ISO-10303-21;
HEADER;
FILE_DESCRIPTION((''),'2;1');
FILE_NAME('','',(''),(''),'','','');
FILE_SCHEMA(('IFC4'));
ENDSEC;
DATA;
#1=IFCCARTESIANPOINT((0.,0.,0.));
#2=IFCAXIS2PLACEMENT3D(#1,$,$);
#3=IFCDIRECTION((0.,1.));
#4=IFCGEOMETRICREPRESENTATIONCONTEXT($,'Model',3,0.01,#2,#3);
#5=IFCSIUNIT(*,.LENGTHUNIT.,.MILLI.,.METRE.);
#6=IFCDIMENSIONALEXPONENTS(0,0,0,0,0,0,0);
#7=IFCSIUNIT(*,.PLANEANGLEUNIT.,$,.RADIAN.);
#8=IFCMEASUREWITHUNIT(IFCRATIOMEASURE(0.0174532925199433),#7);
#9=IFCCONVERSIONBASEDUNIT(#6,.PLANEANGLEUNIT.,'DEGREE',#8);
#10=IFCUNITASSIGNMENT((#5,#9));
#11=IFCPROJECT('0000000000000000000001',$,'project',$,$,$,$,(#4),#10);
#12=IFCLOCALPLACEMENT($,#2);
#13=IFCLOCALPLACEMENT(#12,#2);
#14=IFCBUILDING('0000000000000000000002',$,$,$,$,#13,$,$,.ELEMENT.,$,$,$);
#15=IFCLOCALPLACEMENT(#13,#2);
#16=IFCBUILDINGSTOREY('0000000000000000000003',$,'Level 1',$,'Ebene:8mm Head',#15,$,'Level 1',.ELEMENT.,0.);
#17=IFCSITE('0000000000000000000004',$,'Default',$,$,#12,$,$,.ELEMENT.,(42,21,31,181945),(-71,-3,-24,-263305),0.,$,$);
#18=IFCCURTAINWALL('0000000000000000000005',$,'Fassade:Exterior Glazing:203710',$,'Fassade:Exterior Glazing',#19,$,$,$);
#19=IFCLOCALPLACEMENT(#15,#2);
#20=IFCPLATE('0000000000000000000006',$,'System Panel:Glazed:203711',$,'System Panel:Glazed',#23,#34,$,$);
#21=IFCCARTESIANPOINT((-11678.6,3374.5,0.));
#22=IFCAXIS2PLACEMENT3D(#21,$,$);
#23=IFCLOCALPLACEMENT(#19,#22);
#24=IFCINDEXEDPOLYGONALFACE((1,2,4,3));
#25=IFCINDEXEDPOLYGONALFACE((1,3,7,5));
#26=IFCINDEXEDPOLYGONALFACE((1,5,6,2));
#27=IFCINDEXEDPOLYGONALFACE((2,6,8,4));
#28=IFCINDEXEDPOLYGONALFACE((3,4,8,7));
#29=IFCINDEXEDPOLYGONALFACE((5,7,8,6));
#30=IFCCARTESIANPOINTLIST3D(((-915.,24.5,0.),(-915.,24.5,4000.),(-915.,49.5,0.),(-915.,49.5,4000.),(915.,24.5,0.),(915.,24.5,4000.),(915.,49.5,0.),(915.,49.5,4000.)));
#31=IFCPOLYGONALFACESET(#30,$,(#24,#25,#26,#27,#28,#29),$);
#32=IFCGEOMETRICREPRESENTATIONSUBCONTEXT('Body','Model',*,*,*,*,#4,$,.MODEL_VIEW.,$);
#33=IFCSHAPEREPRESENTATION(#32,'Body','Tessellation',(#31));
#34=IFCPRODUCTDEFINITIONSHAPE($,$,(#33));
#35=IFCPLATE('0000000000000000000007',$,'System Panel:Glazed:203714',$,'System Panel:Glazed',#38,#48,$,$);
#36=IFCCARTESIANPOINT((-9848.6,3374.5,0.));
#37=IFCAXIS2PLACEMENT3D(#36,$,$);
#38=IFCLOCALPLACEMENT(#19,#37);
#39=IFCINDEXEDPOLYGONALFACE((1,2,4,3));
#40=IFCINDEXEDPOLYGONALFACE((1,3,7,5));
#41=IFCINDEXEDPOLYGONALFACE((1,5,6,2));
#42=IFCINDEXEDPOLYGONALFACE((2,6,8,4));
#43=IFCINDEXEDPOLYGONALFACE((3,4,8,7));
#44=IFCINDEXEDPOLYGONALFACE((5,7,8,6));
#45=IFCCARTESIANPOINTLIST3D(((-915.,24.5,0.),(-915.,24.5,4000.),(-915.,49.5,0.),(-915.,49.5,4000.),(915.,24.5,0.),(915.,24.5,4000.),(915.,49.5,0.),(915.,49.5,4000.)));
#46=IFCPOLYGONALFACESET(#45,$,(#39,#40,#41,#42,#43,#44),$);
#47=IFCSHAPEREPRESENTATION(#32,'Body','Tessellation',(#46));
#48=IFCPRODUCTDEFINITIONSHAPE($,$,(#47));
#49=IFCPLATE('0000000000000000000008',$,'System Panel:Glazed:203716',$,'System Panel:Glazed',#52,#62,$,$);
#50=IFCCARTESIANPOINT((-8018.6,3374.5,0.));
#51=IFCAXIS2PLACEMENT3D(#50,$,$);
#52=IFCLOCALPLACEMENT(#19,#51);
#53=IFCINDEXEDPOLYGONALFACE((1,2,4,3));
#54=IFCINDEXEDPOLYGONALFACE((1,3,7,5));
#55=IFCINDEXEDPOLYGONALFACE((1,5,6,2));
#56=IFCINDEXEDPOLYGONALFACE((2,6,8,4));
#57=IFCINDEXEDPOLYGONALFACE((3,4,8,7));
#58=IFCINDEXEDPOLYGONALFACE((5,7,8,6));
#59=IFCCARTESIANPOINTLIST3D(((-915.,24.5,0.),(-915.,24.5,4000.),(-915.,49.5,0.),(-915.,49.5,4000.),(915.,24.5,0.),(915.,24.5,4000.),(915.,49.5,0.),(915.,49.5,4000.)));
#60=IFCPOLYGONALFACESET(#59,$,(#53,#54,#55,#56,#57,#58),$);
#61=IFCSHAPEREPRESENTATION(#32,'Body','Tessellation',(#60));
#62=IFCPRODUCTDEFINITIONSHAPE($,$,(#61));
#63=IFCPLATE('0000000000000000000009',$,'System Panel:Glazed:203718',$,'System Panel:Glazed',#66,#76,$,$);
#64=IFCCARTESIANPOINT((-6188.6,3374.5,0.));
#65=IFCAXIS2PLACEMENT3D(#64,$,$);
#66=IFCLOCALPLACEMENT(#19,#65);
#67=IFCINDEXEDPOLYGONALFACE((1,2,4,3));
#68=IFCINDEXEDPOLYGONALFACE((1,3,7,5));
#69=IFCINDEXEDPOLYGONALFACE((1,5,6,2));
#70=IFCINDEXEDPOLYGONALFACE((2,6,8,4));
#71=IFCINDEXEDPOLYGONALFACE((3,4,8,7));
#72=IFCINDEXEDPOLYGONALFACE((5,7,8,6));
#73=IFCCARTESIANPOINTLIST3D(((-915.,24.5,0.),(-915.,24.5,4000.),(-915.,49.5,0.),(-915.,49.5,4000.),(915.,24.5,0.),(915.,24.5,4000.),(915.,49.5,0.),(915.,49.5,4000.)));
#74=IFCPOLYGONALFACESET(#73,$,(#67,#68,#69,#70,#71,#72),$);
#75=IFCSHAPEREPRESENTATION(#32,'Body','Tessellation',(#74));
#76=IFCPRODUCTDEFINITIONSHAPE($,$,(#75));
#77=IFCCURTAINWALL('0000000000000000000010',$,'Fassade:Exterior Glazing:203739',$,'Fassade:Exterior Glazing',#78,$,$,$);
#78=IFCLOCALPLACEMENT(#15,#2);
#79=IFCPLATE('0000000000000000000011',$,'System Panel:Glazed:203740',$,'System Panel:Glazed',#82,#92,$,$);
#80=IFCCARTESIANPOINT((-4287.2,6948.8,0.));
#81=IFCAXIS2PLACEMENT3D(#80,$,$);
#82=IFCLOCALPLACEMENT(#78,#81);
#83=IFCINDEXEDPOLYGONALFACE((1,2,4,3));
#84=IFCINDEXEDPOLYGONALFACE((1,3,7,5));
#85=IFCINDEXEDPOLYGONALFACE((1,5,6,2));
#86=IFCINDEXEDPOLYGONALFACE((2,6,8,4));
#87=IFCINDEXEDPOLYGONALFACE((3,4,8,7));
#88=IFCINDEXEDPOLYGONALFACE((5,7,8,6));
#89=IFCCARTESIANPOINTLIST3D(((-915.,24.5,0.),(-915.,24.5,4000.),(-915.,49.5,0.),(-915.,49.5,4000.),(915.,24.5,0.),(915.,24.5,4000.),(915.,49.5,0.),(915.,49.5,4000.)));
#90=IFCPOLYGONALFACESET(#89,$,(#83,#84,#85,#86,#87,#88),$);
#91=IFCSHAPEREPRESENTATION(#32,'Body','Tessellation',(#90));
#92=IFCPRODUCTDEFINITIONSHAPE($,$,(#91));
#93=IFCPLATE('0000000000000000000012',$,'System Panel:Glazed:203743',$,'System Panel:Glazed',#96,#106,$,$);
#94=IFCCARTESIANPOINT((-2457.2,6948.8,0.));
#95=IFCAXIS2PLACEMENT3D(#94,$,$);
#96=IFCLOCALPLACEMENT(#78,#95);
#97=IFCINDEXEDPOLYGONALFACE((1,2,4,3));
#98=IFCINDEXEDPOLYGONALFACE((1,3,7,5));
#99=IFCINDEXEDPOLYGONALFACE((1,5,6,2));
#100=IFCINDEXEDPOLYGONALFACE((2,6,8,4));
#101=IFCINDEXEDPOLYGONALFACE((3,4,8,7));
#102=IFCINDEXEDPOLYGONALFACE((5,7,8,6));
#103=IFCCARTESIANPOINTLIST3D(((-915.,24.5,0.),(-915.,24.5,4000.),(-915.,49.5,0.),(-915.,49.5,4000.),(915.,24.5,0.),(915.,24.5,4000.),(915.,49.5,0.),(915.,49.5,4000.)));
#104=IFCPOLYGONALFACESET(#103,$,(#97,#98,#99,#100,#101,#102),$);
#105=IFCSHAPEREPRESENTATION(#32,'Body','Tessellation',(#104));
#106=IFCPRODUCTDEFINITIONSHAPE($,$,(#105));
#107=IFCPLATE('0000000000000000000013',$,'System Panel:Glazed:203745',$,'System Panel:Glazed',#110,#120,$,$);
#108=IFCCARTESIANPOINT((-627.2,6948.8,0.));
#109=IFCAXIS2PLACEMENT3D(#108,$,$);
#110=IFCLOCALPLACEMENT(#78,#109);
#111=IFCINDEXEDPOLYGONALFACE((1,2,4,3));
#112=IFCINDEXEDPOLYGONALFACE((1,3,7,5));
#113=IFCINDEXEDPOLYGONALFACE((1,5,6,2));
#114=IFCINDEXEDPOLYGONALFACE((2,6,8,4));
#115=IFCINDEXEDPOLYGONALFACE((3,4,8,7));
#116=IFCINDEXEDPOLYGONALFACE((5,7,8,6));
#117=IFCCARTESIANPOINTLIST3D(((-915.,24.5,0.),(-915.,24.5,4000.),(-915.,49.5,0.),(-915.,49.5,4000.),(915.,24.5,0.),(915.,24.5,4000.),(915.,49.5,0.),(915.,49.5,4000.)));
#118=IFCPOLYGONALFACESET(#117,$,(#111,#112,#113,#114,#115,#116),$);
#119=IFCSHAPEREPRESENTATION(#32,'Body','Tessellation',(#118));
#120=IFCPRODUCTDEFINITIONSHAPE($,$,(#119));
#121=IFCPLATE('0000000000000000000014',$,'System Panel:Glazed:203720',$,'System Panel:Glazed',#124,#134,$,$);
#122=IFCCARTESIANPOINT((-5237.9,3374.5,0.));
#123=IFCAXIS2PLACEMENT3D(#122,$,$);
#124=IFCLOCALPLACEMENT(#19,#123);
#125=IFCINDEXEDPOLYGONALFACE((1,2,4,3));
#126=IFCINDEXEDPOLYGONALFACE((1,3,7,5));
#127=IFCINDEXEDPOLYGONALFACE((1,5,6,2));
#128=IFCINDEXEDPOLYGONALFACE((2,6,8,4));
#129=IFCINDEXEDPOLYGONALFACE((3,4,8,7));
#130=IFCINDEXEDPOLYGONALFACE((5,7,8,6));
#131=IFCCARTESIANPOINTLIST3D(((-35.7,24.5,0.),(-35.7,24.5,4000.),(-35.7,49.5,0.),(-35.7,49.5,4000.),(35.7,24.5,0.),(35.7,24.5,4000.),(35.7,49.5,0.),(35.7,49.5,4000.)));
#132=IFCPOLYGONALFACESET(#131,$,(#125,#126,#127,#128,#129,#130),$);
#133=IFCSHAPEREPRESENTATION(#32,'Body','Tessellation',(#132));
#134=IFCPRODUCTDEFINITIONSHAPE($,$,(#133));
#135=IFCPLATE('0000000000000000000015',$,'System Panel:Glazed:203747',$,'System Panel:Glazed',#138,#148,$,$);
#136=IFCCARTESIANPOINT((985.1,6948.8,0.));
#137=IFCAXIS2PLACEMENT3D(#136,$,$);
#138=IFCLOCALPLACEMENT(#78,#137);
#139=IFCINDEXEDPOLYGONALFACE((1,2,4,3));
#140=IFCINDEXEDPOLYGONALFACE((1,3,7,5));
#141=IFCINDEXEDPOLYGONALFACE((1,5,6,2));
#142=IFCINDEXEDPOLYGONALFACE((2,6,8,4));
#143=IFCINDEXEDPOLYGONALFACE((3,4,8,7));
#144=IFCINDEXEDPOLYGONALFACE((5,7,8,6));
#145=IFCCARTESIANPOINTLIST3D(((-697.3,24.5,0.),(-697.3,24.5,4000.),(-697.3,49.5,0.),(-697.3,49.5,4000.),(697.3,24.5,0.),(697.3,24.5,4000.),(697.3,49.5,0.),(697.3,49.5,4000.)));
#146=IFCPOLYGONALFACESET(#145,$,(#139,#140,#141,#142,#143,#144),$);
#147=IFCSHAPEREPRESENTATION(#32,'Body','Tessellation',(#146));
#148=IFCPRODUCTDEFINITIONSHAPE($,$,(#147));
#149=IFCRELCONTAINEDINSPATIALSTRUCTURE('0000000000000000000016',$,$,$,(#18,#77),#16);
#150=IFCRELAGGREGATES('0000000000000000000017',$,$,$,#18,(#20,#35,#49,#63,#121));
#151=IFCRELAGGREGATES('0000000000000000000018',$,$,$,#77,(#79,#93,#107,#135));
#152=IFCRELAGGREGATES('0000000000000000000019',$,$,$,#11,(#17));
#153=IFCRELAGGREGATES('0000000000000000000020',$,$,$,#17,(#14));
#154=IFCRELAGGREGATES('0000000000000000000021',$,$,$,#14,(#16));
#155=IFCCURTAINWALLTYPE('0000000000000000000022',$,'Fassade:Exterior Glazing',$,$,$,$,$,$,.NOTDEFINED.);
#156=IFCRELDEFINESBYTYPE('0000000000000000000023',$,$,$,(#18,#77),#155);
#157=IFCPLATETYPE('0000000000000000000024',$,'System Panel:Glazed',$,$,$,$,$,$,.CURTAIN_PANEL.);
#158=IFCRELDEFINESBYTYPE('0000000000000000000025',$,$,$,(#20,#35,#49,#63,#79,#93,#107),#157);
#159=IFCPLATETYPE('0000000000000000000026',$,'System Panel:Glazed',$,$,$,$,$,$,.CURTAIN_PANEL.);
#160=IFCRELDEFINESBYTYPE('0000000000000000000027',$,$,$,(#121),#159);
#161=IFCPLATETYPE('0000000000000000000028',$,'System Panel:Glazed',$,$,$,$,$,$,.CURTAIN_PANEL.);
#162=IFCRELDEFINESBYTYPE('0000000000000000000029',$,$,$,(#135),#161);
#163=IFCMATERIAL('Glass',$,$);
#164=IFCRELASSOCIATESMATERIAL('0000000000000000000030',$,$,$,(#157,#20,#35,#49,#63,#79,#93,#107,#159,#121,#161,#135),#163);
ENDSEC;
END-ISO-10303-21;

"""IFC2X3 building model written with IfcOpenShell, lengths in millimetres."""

from ifc_helpers import new_model, entity, si_unit, converted_unit, direction, frame, origin, origin_2d_with_axis, place, context, subcontext, project, spatial, rectangle, extrude, source, transform, mapped, material, type_object, type_shapes, element, aggregate, save


model = new_model("IFC2X3")

# Units and contexts
model_context = context("Model", 3, precision=0.01, world=origin(), true_north=direction((0.0, 1.0)))
body_context = subcontext(model_context, "Body", "Model", "MODEL_VIEW")
ifc_project = project(units=[si_unit("LENGTHUNIT", "METRE", prefix="MILLI"), converted_unit("PLANEANGLEUNIT", "DEGREE", entity("IfcRatioMeasure", 0.0174532925199433), si_unit("PLANEANGLEUNIT", "RADIAN"), dimensions=[0, 0, 0, 0, 0, 0, 0])], contexts=[model_context])

# Site, building, storey
site_placement = place(None, origin())
site = spatial("IfcSite", under=ifc_project, at=site_placement, Name="Default", CompositionType="ELEMENT", RefLatitude=(42, 21, 31, 181945), RefLongitude=(-71, -3, -24, -263305), RefElevation=0.0)
building_placement = place(site_placement, origin())
building = spatial("IfcBuilding", under=site, at=building_placement, CompositionType="ELEMENT")
storey_placement = place(building_placement, origin())
storey = spatial("IfcBuildingStorey", under=building, at=storey_placement, Name="Level 1", ObjectType="Ebene:8mm Head", LongName="Level 1", CompositionType="ELEMENT", Elevation=0.0)

# Curtain walls, plates
curtain_wall_type = type_object("IfcCurtainWallType", Name="Fassade:Exterior Glazing", PredefinedType="NOTDEFINED")
curtain_wall_1_placement = place(storey_placement, origin())
curtain_wall_1 = element("IfcCurtainWall", 1, at=curtain_wall_1_placement, inside=storey, type_object=curtain_wall_type, Name="Fassade:Exterior Glazing:203710", ObjectType="Fassade:Exterior Glazing")
ifc_material_1 = material(Name="Glass")
plate_type_1 = type_object("IfcPlateType", Name="System Panel:Glazed", PredefinedType="CURTAIN_PANEL", material=ifc_material_1)
shared_shape_1 = source(origin(), body_context, "Body", "SweptSolid", [
    extrude(rectangle(XDim=25.0, YDim=1830.0, at=origin_2d_with_axis()), frame((0.0, 37.0, 0.0), z_axis=(0.0, 0.0, 1.0), x_axis=(0.0, 1.0, 0.0)), (0.0, 0.0, 1.0), 4000.0),
])
type_shapes(plate_type_1, [shared_shape_1])
plate_1_placement = place(curtain_wall_1_placement, frame((-11678.6, 3374.5, 0.0)))
plate_1 = element("IfcPlate", 2, at=plate_1_placement, type_object=plate_type_1, material=ifc_material_1, Name="System Panel:Glazed:203711", ObjectType="System Panel:Glazed", context=body_context, shape_type="MappedRepresentation", body=[
    mapped(shared_shape_1, transform((0.0, 0.0, 0.0), scale=1.0)),
])
plate_2_placement = place(curtain_wall_1_placement, frame((-9848.6, 3374.5, 0.0)))
plate_2 = element("IfcPlate", 3, at=plate_2_placement, type_object=plate_type_1, material=ifc_material_1, Name="System Panel:Glazed:203714", ObjectType="System Panel:Glazed", context=body_context, shape_type="MappedRepresentation", body=[
    mapped(shared_shape_1, transform((0.0, 0.0, 0.0), scale=1.0)),
])
plate_3_placement = place(curtain_wall_1_placement, frame((-8018.6, 3374.5, 0.0)))
plate_3 = element("IfcPlate", 4, at=plate_3_placement, type_object=plate_type_1, material=ifc_material_1, Name="System Panel:Glazed:203716", ObjectType="System Panel:Glazed", context=body_context, shape_type="MappedRepresentation", body=[
    mapped(shared_shape_1, transform((0.0, 0.0, 0.0), scale=1.0)),
])
plate_4_placement = place(curtain_wall_1_placement, frame((-6188.6, 3374.5, 0.0)))
plate_4 = element("IfcPlate", 5, at=plate_4_placement, type_object=plate_type_1, material=ifc_material_1, Name="System Panel:Glazed:203718", ObjectType="System Panel:Glazed", context=body_context, shape_type="MappedRepresentation", body=[
    mapped(shared_shape_1, transform((0.0, 0.0, 0.0), scale=1.0)),
])
curtain_wall_2_placement = place(storey_placement, origin())
curtain_wall_2 = element("IfcCurtainWall", 6, at=curtain_wall_2_placement, inside=storey, type_object=curtain_wall_type, Name="Fassade:Exterior Glazing:203739", ObjectType="Fassade:Exterior Glazing")
plate_5_placement = place(curtain_wall_2_placement, frame((-4287.2, 6948.8, 0.0)))
plate_5 = element("IfcPlate", 7, at=plate_5_placement, type_object=plate_type_1, material=ifc_material_1, Name="System Panel:Glazed:203740", ObjectType="System Panel:Glazed", context=body_context, shape_type="MappedRepresentation", body=[
    mapped(shared_shape_1, transform((0.0, 0.0, 0.0), scale=1.0)),
])
plate_6_placement = place(curtain_wall_2_placement, frame((-2457.2, 6948.8, 0.0)))
plate_6 = element("IfcPlate", 8, at=plate_6_placement, type_object=plate_type_1, material=ifc_material_1, Name="System Panel:Glazed:203743", ObjectType="System Panel:Glazed", context=body_context, shape_type="MappedRepresentation", body=[
    mapped(shared_shape_1, transform((0.0, 0.0, 0.0), scale=1.0)),
])
plate_7_placement = place(curtain_wall_2_placement, frame((-627.2, 6948.8, 0.0)))
plate_7 = element("IfcPlate", 9, at=plate_7_placement, type_object=plate_type_1, material=ifc_material_1, Name="System Panel:Glazed:203745", ObjectType="System Panel:Glazed", context=body_context, shape_type="MappedRepresentation", body=[
    mapped(shared_shape_1, transform((0.0, 0.0, 0.0), scale=1.0)),
])

# Plates
plate_type_2 = type_object("IfcPlateType", Name="System Panel:Glazed", PredefinedType="CURTAIN_PANEL", material=ifc_material_1)
shared_shape_2 = source(origin(), body_context, "Body", "SweptSolid", [
    extrude(rectangle(XDim=25.0, YDim=71.4, at=origin_2d_with_axis()), frame((0.0, 37.0, 0.0), z_axis=(0.0, 0.0, 1.0), x_axis=(0.0, 1.0, 0.0)), (0.0, 0.0, 1.0), 4000.0),
])
type_shapes(plate_type_2, [shared_shape_2])
plate_8_placement = place(curtain_wall_1_placement, frame((-5237.9, 3374.5, 0.0)))
plate_8 = element("IfcPlate", 10, at=plate_8_placement, type_object=plate_type_2, material=ifc_material_1, Name="System Panel:Glazed:203720", ObjectType="System Panel:Glazed", context=body_context, shape_type="MappedRepresentation", body=[
    mapped(shared_shape_2, transform((0.0, 0.0, 0.0), scale=1.0)),
])
aggregate(curtain_wall_1, [plate_1, plate_2, plate_3, plate_4, plate_8])
plate_type_3 = type_object("IfcPlateType", Name="System Panel:Glazed", PredefinedType="CURTAIN_PANEL", material=ifc_material_1)
shared_shape_3 = source(origin(), body_context, "Body", "SweptSolid", [
    extrude(rectangle(XDim=25.0, YDim=1394.6, at=origin_2d_with_axis()), frame((0.0, 37.0, 0.0), z_axis=(0.0, 0.0, 1.0), x_axis=(0.0, 1.0, 0.0)), (0.0, 0.0, 1.0), 4000.0),
])
type_shapes(plate_type_3, [shared_shape_3])
plate_9_placement = place(curtain_wall_2_placement, frame((985.1, 6948.8, 0.0)))
plate_9 = element("IfcPlate", 11, at=plate_9_placement, type_object=plate_type_3, material=ifc_material_1, Name="System Panel:Glazed:203747", ObjectType="System Panel:Glazed", context=body_context, shape_type="MappedRepresentation", body=[
    mapped(shared_shape_3, transform((0.0, 0.0, 0.0), scale=1.0)),
])
aggregate(curtain_wall_2, [plate_5, plate_6, plate_7, plate_9])

save(model, "model.ifc")
